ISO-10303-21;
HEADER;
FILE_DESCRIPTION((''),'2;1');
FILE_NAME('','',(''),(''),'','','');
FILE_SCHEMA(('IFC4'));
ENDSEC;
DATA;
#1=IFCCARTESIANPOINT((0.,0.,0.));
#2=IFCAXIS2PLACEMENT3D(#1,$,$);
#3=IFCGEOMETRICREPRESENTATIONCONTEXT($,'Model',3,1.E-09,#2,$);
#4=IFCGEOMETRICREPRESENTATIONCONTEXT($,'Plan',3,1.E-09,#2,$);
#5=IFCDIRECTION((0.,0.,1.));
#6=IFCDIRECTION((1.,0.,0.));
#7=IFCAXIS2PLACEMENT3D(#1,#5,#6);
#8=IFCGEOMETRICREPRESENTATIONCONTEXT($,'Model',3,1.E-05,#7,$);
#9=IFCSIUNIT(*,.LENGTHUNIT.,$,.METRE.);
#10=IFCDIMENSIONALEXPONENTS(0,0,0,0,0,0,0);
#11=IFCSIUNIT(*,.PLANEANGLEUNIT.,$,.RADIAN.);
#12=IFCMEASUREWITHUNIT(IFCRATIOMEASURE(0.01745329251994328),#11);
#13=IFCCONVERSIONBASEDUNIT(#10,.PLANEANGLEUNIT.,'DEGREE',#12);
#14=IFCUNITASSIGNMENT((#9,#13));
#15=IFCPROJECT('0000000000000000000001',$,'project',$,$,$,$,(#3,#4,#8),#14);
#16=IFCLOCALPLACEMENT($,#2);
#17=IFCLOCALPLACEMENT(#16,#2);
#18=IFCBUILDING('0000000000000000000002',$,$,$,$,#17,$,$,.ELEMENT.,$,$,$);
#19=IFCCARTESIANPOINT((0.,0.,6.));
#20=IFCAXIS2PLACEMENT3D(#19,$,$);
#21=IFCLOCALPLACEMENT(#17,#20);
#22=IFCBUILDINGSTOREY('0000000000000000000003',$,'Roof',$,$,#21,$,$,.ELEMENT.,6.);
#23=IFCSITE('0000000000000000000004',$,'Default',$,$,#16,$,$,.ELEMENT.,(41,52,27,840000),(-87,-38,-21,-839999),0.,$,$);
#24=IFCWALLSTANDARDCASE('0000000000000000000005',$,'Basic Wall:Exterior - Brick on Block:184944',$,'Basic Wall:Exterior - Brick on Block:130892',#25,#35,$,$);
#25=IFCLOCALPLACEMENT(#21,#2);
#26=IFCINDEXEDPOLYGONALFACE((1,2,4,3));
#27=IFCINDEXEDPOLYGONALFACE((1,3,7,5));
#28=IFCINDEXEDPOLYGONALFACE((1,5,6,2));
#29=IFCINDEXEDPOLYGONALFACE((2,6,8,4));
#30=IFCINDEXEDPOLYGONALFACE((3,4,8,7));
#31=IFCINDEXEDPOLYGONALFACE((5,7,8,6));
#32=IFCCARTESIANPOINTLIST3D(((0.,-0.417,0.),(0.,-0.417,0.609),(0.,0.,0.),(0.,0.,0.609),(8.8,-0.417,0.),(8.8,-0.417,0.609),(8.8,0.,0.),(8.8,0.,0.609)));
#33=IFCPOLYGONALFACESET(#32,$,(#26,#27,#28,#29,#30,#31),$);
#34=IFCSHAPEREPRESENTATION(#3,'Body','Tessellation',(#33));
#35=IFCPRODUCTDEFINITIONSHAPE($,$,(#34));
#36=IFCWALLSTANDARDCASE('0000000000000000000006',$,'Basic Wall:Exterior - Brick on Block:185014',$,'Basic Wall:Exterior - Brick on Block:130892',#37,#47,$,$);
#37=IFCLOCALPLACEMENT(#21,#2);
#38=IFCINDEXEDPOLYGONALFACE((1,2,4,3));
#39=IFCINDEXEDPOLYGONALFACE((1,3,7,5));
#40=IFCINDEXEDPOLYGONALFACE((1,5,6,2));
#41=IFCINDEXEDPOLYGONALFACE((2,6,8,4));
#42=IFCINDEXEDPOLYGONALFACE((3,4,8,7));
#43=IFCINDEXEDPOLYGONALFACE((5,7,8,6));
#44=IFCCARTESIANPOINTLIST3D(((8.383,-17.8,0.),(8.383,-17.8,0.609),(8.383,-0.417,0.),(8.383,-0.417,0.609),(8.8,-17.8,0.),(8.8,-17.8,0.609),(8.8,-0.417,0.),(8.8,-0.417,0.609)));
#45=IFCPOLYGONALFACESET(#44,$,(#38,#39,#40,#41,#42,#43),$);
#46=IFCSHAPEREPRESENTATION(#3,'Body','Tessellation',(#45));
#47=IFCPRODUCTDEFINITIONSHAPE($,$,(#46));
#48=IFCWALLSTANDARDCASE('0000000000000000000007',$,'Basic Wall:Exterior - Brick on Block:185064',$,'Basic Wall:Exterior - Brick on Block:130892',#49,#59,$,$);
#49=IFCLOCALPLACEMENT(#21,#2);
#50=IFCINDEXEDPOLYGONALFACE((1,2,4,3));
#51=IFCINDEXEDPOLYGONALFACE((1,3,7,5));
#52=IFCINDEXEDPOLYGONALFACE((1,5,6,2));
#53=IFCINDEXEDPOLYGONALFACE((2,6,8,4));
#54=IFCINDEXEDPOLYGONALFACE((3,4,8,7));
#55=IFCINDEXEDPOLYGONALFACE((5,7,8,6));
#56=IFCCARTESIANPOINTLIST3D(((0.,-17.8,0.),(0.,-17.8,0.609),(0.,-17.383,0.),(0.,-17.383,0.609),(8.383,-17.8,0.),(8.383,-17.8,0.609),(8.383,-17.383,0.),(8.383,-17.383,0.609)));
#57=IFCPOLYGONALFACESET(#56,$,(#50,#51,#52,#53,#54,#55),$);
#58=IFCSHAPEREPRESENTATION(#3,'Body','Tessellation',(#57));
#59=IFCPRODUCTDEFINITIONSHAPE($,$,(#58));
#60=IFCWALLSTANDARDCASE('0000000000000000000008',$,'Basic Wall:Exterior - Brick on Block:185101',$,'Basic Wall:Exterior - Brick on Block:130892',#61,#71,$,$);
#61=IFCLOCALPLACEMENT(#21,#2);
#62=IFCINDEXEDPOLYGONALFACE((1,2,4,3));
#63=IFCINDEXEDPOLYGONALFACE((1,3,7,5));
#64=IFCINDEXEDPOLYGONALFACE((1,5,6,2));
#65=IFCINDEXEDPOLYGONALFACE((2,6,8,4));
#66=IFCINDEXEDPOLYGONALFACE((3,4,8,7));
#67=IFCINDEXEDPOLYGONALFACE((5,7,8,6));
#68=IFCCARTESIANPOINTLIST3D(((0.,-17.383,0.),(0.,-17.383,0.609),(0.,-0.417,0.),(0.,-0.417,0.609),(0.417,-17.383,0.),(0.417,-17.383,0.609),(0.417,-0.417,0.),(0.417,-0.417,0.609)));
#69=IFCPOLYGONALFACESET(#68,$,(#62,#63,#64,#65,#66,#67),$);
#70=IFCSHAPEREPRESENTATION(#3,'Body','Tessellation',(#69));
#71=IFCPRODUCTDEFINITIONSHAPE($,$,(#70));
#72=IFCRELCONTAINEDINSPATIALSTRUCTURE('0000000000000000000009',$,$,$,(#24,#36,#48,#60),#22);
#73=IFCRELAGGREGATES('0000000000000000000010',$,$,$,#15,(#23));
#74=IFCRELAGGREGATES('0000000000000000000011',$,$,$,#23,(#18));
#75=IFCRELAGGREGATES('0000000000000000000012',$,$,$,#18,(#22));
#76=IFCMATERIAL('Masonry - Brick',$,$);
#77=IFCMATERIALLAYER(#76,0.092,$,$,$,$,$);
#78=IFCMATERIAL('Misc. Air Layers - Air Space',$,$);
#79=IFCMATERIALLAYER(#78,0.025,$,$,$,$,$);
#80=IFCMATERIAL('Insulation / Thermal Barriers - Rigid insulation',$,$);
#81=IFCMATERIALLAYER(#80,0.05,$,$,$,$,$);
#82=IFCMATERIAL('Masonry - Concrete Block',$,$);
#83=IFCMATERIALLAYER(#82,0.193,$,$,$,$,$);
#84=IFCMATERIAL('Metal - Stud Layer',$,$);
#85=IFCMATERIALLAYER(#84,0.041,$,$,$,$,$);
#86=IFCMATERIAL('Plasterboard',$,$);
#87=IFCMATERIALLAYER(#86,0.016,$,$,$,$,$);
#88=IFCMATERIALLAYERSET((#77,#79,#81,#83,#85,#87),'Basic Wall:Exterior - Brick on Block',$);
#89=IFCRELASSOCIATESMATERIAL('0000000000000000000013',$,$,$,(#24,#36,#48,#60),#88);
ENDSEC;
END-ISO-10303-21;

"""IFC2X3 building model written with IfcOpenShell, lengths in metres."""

from ifc_helpers import new_model, entity, si_unit, converted_unit, frame, frame_2d, origin, origin_with_axes, place, context, project, spatial, rectangle, extrude, material, layer, layer_set, layer_usage, element, save


model = new_model("IFC2X3")

# Units and contexts
model_context_1 = context("Model", 3, precision=1e-09, world=origin())
plan_context = context("Plan", 3, precision=1e-09, world=origin())
model_context_2 = context("Model", 3, precision=1e-05, world=origin_with_axes())
ifc_project = project(units=[si_unit("LENGTHUNIT", "METRE"), converted_unit("PLANEANGLEUNIT", "DEGREE", entity("IfcRatioMeasure", 0.01745329251994328), si_unit("PLANEANGLEUNIT", "RADIAN"), dimensions=[0, 0, 0, 0, 0, 0, 0])], contexts=[model_context_1, plan_context, model_context_2])

# Site, building, storey
site_placement = place(None, origin())
site = spatial("IfcSite", under=ifc_project, at=site_placement, Name="Default", CompositionType="ELEMENT", RefLatitude=(41, 52, 27, 840000), RefLongitude=(-87, -38, -21, -839999), RefElevation=0.0)
building_placement = place(site_placement, origin())
building = spatial("IfcBuilding", under=site, at=building_placement, CompositionType="ELEMENT")
storey_placement = place(building_placement, frame((0.0, 0.0, 6.0)))
storey = spatial("IfcBuildingStorey", under=building, at=storey_placement, Name="Roof", CompositionType="ELEMENT", Elevation=6.0)

# Walls
ifc_material_1 = material(Name="Masonry - Brick")
ifc_layer_1 = layer(ifc_material_1, 0.092)
ifc_material_2 = material(Name="Misc. Air Layers - Air Space")
ifc_layer_2 = layer(ifc_material_2, 0.025)
ifc_material_3 = material(Name="Insulation / Thermal Barriers - Rigid insulation")
ifc_layer_3 = layer(ifc_material_3, 0.05)
ifc_material_4 = material(Name="Masonry - Concrete Block")
ifc_layer_4 = layer(ifc_material_4, 0.193)
ifc_material_5 = material(Name="Metal - Stud Layer")
ifc_layer_5 = layer(ifc_material_5, 0.041)
ifc_material_6 = material(Name="Plasterboard")
ifc_layer_6 = layer(ifc_material_6, 0.016)
ifc_layer_set = layer_set([ifc_layer_1, ifc_layer_2, ifc_layer_3, ifc_layer_4, ifc_layer_5, ifc_layer_6], Name="Basic Wall:Exterior - Brick on Block")
ifc_layer_usage_1 = layer_usage(ifc_layer_set, "AXIS2", "NEGATIVE", 0.2085)
wall_1_placement = place(storey_placement, frame((0.0, -0.2085, 0.0)))
element("IfcWallStandardCase", 1, at=wall_1_placement, inside=storey, material=ifc_layer_usage_1, Name="Basic Wall:Exterior - Brick on Block:184944", ObjectType="Basic Wall:Exterior - Brick on Block:130892", context=model_context_1, shape_type="SweptSolid", body=[
    extrude(rectangle(XDim=8.8, YDim=0.417, at=frame_2d((4.4, 0.0), x_axis=(-1.0, 0.0))), origin(), (0.0, 0.0, 1.0), 0.609),
])
ifc_layer_usage_2 = layer_usage(ifc_layer_set, "AXIS2", "NEGATIVE", 0.2085)
wall_2_placement = place(storey_placement, frame((8.5915, -0.417, 0.0), z_axis=(0.0, 0.0, 1.0), x_axis=(0.0, -1.0, 0.0)))
element("IfcWallStandardCase", 2, at=wall_2_placement, inside=storey, material=ifc_layer_usage_2, Name="Basic Wall:Exterior - Brick on Block:185014", ObjectType="Basic Wall:Exterior - Brick on Block:130892", context=model_context_1, shape_type="SweptSolid", body=[
    extrude(rectangle(XDim=17.383, YDim=0.417, at=frame_2d((8.6915, 0.0), x_axis=(-1.0, 0.0))), origin(), (0.0, 0.0, 1.0), 0.609),
])
ifc_layer_usage_3 = layer_usage(ifc_layer_set, "AXIS2", "NEGATIVE", 0.2085)
wall_3_placement = place(storey_placement, frame((8.383, -17.5915, 0.0), z_axis=(0.0, 0.0, 1.0), x_axis=(-1.0, 0.0, 0.0)))
element("IfcWallStandardCase", 3, at=wall_3_placement, inside=storey, material=ifc_layer_usage_3, Name="Basic Wall:Exterior - Brick on Block:185064", ObjectType="Basic Wall:Exterior - Brick on Block:130892", context=model_context_1, shape_type="SweptSolid", body=[
    extrude(rectangle(XDim=8.383, YDim=0.417, at=frame_2d((4.1915, 0.0), x_axis=(-1.0, 0.0))), origin(), (0.0, 0.0, 1.0), 0.609),
])
ifc_layer_usage_4 = layer_usage(ifc_layer_set, "AXIS2", "NEGATIVE", 0.2085)
wall_4_placement = place(storey_placement, frame((0.2085, -17.383, 0.0), z_axis=(0.0, 0.0, 1.0), x_axis=(0.0, 1.0, 0.0)))
element("IfcWallStandardCase", 4, at=wall_4_placement, inside=storey, material=ifc_layer_usage_4, Name="Basic Wall:Exterior - Brick on Block:185101", ObjectType="Basic Wall:Exterior - Brick on Block:130892", context=model_context_1, shape_type="SweptSolid", body=[
    extrude(rectangle(XDim=16.966, YDim=0.417, at=frame_2d((8.483, 0.0), x_axis=(-1.0, 0.0))), origin(), (0.0, 0.0, 1.0), 0.609),
])

save(model, "model.ifc")
